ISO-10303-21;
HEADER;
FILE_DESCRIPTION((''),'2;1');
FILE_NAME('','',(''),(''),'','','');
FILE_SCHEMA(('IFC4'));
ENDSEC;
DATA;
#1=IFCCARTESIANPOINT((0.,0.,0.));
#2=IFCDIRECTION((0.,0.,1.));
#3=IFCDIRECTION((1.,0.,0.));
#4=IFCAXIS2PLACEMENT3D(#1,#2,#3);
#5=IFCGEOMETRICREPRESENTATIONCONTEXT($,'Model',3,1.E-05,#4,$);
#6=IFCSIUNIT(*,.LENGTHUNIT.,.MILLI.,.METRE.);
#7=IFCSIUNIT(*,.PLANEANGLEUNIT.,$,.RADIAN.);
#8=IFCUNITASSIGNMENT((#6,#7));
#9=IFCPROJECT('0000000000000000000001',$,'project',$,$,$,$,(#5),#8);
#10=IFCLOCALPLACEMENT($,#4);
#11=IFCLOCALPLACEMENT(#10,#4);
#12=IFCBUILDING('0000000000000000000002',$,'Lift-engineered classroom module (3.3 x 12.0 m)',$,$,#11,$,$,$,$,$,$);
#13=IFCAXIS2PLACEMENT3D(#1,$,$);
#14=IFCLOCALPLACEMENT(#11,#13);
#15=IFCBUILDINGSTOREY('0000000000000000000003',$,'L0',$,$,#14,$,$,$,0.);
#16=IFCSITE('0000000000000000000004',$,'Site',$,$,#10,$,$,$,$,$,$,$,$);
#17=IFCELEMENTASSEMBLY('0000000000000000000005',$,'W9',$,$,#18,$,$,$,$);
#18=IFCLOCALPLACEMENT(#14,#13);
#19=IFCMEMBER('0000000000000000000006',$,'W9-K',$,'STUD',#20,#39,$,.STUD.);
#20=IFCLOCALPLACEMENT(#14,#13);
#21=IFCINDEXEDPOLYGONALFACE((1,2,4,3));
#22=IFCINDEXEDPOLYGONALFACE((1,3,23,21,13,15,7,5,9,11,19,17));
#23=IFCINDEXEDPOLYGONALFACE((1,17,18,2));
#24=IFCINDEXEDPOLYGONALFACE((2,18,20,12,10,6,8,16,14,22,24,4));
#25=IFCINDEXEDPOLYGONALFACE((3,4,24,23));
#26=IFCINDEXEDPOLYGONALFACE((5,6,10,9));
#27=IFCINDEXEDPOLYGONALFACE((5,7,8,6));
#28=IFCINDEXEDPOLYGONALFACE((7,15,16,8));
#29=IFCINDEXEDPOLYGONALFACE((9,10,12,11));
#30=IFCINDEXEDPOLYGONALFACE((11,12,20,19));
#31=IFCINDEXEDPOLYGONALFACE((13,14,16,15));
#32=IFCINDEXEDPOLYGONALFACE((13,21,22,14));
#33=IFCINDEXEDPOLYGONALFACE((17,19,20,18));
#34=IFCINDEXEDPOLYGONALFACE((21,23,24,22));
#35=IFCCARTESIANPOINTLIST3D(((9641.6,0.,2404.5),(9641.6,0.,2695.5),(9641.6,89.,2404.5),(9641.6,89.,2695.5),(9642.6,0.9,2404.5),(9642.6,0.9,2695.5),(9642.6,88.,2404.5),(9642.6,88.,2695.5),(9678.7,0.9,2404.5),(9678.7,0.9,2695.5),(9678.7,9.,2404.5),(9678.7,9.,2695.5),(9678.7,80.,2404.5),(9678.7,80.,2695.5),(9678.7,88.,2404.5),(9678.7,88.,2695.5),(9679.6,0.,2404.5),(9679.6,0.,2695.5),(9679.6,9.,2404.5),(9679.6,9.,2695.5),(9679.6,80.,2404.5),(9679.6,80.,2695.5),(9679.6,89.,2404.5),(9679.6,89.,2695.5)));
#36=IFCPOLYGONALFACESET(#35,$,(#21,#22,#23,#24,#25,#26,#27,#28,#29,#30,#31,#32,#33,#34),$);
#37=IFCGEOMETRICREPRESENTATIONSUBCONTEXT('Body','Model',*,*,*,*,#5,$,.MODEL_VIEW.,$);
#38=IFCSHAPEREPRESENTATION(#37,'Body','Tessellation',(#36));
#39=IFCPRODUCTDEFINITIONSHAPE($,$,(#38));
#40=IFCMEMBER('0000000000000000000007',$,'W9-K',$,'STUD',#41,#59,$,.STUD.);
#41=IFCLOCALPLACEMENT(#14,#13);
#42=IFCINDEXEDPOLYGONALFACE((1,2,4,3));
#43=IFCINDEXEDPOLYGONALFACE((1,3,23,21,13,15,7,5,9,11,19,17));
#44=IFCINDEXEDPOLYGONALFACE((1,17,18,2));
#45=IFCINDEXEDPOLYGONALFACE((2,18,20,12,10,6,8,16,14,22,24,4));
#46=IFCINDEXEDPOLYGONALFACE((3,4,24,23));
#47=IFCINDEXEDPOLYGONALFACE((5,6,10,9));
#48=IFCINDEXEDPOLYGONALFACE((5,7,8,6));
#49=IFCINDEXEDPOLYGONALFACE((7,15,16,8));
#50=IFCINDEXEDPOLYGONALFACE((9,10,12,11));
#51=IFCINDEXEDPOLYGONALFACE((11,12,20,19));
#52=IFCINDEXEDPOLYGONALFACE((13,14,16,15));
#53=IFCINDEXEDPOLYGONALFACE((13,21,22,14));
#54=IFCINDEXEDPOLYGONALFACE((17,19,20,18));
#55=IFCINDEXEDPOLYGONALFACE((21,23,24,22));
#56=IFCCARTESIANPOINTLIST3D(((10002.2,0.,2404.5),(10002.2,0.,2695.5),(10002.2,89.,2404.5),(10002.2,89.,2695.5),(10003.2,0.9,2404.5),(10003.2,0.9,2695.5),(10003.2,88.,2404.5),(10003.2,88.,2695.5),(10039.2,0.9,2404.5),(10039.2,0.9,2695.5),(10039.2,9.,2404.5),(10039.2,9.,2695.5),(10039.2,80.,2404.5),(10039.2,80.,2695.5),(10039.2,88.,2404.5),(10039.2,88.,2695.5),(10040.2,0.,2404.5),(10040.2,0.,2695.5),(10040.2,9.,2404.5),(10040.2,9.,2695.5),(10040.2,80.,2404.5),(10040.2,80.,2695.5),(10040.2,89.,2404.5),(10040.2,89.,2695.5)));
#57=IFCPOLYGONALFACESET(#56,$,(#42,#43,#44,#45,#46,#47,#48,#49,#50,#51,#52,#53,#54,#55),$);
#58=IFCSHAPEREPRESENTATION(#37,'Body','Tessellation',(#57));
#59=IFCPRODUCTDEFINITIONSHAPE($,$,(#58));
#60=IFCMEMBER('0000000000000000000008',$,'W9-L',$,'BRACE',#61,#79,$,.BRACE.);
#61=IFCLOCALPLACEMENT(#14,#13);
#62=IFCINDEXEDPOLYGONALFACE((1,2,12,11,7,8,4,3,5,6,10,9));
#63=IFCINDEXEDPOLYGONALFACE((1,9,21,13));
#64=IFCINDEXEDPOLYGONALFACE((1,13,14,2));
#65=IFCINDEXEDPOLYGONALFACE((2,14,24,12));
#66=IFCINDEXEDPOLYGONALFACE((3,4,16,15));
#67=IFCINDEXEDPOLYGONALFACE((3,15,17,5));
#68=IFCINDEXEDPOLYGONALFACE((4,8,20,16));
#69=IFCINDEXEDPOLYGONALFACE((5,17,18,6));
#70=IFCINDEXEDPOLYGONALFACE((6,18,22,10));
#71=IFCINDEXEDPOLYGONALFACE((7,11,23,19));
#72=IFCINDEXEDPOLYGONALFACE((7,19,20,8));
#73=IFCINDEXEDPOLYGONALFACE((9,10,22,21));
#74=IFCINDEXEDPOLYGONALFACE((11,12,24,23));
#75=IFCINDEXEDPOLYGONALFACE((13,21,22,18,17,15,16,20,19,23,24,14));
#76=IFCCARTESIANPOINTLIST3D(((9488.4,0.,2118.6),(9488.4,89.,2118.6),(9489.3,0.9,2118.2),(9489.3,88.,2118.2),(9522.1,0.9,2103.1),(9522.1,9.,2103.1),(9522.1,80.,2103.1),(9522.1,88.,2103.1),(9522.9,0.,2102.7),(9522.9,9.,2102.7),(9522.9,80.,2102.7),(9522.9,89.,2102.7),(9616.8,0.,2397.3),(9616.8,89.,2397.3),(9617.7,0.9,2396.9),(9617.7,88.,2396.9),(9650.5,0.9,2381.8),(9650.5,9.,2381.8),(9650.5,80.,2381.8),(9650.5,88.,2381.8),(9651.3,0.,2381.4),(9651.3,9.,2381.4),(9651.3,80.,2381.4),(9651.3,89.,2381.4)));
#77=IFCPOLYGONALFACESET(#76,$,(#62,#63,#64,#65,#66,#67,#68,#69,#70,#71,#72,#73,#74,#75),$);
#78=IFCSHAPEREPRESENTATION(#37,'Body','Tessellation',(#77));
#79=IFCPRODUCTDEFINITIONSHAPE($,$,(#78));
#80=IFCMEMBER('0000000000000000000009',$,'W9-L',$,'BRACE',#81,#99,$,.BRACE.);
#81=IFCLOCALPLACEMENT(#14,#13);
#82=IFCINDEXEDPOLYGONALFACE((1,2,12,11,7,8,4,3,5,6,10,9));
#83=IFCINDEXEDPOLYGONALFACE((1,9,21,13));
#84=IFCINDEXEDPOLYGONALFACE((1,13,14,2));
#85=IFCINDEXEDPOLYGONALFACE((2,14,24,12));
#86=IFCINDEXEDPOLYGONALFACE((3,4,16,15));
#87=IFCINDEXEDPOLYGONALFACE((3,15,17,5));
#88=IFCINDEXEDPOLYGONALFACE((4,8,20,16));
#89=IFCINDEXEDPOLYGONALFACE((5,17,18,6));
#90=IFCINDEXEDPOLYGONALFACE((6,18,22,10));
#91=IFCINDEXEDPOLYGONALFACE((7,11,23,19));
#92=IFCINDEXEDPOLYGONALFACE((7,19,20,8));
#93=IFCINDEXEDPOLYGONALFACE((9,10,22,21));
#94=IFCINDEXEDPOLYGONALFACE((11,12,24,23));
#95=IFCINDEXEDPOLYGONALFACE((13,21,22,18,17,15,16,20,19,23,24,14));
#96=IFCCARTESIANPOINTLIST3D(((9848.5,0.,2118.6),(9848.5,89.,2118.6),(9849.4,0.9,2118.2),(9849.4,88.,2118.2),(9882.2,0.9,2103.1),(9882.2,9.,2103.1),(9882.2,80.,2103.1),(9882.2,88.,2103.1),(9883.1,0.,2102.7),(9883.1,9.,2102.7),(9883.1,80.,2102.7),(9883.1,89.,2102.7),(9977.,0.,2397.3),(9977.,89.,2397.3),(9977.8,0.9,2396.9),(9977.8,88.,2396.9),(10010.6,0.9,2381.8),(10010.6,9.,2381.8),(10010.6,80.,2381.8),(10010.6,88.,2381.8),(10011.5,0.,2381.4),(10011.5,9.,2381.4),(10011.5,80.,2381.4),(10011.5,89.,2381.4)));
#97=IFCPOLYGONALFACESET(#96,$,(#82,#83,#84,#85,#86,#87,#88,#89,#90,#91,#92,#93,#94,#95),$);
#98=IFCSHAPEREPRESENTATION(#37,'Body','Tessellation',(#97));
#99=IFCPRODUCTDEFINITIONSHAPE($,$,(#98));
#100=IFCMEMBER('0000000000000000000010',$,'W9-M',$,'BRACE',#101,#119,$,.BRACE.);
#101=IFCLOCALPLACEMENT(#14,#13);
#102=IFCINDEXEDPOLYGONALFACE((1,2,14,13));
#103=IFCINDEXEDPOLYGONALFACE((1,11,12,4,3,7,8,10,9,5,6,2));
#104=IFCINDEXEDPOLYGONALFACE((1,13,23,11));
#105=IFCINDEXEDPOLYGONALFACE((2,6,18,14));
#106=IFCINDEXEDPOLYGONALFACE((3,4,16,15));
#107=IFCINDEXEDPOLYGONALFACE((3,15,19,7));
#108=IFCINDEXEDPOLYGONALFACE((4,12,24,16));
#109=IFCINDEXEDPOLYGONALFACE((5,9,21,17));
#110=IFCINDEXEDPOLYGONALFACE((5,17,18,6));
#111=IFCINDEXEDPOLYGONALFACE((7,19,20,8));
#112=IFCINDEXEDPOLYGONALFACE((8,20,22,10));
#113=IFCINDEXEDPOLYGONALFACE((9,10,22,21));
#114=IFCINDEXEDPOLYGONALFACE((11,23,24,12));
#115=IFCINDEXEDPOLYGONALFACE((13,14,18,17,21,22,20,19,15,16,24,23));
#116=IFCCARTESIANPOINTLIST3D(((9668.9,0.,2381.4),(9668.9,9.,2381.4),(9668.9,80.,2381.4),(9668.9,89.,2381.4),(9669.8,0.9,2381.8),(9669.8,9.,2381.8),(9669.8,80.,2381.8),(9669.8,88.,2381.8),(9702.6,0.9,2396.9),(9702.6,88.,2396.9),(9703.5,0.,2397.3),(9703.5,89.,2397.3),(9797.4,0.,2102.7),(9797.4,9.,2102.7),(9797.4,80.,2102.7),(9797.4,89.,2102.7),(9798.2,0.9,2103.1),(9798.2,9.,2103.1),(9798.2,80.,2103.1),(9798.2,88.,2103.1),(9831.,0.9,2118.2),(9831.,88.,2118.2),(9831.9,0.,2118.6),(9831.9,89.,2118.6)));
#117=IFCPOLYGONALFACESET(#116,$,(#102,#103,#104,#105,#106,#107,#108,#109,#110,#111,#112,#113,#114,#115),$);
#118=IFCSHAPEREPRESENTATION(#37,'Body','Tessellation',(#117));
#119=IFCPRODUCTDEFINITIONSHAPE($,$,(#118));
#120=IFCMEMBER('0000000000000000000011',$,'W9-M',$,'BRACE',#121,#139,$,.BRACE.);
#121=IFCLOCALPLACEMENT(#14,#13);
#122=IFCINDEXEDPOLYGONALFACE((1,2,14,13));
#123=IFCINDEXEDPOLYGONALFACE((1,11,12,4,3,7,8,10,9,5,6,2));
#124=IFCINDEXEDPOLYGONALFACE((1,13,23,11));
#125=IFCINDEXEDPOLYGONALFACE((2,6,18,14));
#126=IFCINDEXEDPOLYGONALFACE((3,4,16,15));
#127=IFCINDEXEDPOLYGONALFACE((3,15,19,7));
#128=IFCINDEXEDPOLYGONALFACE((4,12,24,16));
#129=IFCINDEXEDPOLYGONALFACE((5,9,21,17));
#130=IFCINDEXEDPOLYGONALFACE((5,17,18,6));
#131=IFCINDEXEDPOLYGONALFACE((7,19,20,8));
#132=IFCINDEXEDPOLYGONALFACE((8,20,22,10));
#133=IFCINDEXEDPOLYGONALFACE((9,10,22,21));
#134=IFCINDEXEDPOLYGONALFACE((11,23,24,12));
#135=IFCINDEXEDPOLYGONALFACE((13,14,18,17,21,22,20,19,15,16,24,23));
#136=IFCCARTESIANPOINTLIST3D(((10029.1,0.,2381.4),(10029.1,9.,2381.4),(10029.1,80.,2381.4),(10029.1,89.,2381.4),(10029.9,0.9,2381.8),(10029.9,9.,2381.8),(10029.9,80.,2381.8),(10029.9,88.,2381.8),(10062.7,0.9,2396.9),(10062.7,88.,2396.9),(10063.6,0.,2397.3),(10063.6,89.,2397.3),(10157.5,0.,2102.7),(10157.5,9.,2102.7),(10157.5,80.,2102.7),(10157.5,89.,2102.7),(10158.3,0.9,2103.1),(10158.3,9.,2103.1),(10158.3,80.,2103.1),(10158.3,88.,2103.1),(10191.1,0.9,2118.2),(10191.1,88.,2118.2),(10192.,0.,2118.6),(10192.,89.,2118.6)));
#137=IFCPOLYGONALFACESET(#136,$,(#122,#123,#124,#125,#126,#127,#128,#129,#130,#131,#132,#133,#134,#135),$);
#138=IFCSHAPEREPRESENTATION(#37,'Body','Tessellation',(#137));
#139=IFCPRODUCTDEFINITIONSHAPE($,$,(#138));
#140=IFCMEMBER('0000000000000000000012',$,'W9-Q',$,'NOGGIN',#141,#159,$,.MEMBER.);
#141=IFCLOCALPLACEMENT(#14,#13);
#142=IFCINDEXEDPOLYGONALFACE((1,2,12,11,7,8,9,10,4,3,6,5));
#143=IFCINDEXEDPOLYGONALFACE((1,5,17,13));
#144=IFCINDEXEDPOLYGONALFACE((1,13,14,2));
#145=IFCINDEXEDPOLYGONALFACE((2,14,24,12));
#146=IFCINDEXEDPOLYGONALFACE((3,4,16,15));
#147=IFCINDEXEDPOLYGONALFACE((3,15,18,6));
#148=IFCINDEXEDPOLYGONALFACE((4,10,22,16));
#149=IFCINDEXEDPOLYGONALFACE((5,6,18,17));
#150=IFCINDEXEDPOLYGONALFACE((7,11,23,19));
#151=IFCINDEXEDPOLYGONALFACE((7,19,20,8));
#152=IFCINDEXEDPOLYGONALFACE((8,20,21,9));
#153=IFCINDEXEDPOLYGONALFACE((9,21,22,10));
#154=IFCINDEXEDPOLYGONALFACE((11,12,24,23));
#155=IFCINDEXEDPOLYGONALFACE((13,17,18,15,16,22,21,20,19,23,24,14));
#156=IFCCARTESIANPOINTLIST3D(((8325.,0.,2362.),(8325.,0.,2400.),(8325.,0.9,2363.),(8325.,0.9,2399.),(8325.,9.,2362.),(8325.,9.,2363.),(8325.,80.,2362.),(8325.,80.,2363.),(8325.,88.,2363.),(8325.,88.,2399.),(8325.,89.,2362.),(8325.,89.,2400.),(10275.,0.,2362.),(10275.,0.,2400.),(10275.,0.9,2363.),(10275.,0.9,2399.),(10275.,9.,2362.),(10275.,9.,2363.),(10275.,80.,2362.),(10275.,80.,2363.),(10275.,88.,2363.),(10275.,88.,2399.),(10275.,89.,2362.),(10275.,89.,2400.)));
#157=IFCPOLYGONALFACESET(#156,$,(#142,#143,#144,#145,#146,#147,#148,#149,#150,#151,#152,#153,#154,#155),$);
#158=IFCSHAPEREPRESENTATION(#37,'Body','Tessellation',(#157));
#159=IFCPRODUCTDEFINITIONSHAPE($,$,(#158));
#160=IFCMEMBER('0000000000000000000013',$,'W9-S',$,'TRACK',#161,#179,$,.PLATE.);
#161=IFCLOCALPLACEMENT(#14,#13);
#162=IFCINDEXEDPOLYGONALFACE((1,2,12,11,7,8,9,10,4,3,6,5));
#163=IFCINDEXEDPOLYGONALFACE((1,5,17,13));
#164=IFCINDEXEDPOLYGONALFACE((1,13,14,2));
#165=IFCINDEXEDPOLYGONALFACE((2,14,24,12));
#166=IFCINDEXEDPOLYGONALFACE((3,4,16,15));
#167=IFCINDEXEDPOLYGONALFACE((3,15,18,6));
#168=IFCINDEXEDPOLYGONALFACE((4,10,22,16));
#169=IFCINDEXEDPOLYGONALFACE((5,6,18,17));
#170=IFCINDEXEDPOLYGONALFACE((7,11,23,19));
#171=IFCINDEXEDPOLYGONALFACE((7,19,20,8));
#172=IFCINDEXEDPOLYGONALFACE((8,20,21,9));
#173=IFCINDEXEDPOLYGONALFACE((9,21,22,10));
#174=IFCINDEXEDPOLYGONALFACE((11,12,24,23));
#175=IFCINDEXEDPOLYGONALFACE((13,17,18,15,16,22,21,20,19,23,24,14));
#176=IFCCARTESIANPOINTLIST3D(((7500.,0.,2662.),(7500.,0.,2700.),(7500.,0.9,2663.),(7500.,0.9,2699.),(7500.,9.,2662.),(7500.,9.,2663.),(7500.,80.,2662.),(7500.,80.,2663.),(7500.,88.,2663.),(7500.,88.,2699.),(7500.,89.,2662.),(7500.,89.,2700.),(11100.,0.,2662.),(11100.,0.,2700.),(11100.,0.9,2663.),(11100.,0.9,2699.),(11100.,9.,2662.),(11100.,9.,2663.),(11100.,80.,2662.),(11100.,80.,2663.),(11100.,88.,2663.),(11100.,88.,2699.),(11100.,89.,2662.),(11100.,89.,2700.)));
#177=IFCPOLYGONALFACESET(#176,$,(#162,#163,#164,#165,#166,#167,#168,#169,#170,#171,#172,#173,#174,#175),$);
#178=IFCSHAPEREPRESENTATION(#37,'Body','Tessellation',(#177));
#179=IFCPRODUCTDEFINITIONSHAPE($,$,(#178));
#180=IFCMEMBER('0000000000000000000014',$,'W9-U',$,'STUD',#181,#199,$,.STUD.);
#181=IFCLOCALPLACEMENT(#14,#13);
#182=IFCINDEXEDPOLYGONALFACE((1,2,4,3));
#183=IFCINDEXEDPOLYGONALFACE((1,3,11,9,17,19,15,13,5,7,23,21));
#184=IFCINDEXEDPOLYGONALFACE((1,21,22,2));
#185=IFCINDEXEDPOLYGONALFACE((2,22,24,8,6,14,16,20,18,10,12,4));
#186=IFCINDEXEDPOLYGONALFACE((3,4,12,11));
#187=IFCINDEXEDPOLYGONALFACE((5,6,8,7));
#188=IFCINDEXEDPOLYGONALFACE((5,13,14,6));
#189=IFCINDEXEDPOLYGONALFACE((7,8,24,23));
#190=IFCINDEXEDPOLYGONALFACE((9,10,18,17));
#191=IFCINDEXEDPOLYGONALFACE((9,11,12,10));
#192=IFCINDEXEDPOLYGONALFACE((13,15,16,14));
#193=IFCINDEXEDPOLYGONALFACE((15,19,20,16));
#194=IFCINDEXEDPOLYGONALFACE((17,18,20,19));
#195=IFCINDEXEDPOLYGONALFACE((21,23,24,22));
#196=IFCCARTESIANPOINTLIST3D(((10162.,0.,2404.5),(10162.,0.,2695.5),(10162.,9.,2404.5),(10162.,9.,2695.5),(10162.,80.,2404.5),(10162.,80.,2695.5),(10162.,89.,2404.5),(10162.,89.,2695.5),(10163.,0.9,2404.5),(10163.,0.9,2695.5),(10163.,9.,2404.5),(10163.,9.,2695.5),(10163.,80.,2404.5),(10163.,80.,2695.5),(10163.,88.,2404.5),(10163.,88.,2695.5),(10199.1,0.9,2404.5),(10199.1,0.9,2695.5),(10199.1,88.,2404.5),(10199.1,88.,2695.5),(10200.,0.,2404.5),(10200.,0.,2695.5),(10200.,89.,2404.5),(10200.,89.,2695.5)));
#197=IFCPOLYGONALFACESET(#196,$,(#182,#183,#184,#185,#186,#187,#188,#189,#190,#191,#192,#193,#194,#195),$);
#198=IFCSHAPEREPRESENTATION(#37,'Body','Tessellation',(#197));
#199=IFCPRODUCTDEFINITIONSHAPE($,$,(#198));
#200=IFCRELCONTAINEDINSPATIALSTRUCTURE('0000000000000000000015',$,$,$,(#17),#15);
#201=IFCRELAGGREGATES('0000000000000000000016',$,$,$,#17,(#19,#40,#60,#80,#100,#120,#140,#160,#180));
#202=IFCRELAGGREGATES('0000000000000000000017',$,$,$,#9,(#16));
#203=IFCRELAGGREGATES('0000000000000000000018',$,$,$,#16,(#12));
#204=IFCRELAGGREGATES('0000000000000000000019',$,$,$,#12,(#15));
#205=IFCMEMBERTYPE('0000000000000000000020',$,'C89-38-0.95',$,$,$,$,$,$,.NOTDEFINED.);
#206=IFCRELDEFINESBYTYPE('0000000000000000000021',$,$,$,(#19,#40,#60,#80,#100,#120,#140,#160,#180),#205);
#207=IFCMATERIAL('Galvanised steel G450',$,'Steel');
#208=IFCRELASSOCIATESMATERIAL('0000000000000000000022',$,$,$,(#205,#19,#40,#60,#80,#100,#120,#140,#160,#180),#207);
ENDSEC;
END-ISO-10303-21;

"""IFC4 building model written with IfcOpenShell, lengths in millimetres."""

from ifc_helpers import new_model, si_unit, frame, origin, origin_with_axes, origin_2d, place, context, subcontext, project, spatial, c_section, extrude, material, material_profile, profile_set, profile_usage, type_object, element, aggregate, save


model = new_model("IFC4")

# Units and contexts
model_context = context("Model", 3, precision=1e-05, world=origin_with_axes())
body_context = subcontext(model_context, "Body", "Model", "MODEL_VIEW")
ifc_project = project(units=[si_unit("LENGTHUNIT", "METRE", prefix="MILLI"), si_unit("PLANEANGLEUNIT", "RADIAN")], contexts=[model_context])

# Site, building, storey
site_placement = place(None, origin_with_axes())
site = spatial("IfcSite", under=ifc_project, at=site_placement, Name="Site")
building_placement = place(site_placement, origin_with_axes())
building = spatial("IfcBuilding", under=site, at=building_placement, Name="Lift-engineered classroom module (3.3 x 12.0 m)")
storey_placement = place(building_placement, origin())
storey = spatial("IfcBuildingStorey", under=building, at=storey_placement, Name="L0", Elevation=0.0)

# Element assembly, members
assembly_1_placement = place(storey_placement, frame((7500.0, 44.5, 0.0)))
assembly_1 = element("IfcElementAssembly", 1, at=assembly_1_placement, inside=storey, Name="W9")
ifc_material = material(Name="Galvanised steel G450", Category="Steel")
ifc_material_profile = material_profile(ifc_material, c_section(Depth=89.0, Width=38.0, WallThickness=0.9, Girth=9.0, at=origin_2d()), Name="C89-38-0.95")
ifc_profile_set = profile_set([ifc_material_profile], Name="C89-38-0.95")
ifc_profile_usage = profile_usage(ifc_profile_set)
member_type = type_object("IfcMemberType", Name="C89-38-0.95", PredefinedType="NOTDEFINED", material=ifc_profile_set)
member_1_placement = place(assembly_1_placement, frame((2160.6, 0.0, 2695.5), z_axis=(0.0, 0.0, -1.0), x_axis=(1.0, 0.0, 0.0)))
member_1 = element("IfcMember", 2, at=member_1_placement, type_object=member_type, material=ifc_profile_usage, Name="W9-K", ObjectType="STUD", PredefinedType="STUD", context=body_context, shape_type="SweptSolid", body=[
    extrude(c_section(Depth=89.0, Width=38.0, WallThickness=0.9, Girth=9.0, at=origin_2d()), origin(), (0.0, 0.0, 1.0), 291.0),
])
member_2_placement = place(assembly_1_placement, frame((2521.2, 0.0, 2695.5), z_axis=(0.0, 0.0, -1.0), x_axis=(1.0, 0.0, 0.0)))
member_2 = element("IfcMember", 3, at=member_2_placement, type_object=member_type, material=ifc_profile_usage, Name="W9-K", ObjectType="STUD", PredefinedType="STUD", context=body_context, shape_type="SweptSolid", body=[
    extrude(c_section(Depth=89.0, Width=38.0, WallThickness=0.9, Girth=9.0, at=origin_2d()), origin(), (0.0, 0.0, 1.0), 291.0),
])
member_3_placement = place(assembly_1_placement, frame((2134.1, 0.0, 2389.3), z_axis=(-0.418465, 0.0, -0.908233), x_axis=(0.908233, 0.0, -0.418465)))
member_3 = element("IfcMember", 4, at=member_3_placement, type_object=member_type, material=ifc_profile_usage, Name="W9-L", ObjectType="BRACE", PredefinedType="BRACE", context=body_context, shape_type="SweptSolid", body=[
    extrude(c_section(Depth=89.0, Width=38.0, WallThickness=0.9, Girth=9.0, at=origin_2d()), origin(), (0.0, 0.0, 1.0), 306.9),
])
member_4_placement = place(assembly_1_placement, frame((2494.2, 0.0, 2389.3), z_axis=(-0.418465, 0.0, -0.908233), x_axis=(0.908233, 0.0, -0.418465)))
member_4 = element("IfcMember", 5, at=member_4_placement, type_object=member_type, material=ifc_profile_usage, Name="W9-L", ObjectType="BRACE", PredefinedType="BRACE", context=body_context, shape_type="SweptSolid", body=[
    extrude(c_section(Depth=89.0, Width=38.0, WallThickness=0.9, Girth=9.0, at=origin_2d()), origin(), (0.0, 0.0, 1.0), 306.9),
])
member_5_placement = place(assembly_1_placement, frame((2314.6, 0.0, 2110.6), z_axis=(-0.418465, 0.0, 0.908233), x_axis=(-0.908233, 0.0, -0.418465)))
member_5 = element("IfcMember", 6, at=member_5_placement, type_object=member_type, material=ifc_profile_usage, Name="W9-M", ObjectType="BRACE", PredefinedType="BRACE", context=body_context, shape_type="SweptSolid", body=[
    extrude(c_section(Depth=89.0, Width=38.0, WallThickness=0.9, Girth=9.0, at=origin_2d()), origin(), (0.0, 0.0, 1.0), 306.9),
])
member_6_placement = place(assembly_1_placement, frame((2674.7, 0.0, 2110.6), z_axis=(-0.418465, 0.0, 0.908233), x_axis=(-0.908233, 0.0, -0.418465)))
member_6 = element("IfcMember", 7, at=member_6_placement, type_object=member_type, material=ifc_profile_usage, Name="W9-M", ObjectType="BRACE", PredefinedType="BRACE", context=body_context, shape_type="SweptSolid", body=[
    extrude(c_section(Depth=89.0, Width=38.0, WallThickness=0.9, Girth=9.0, at=origin_2d()), origin(), (0.0, 0.0, 1.0), 306.9),
])
member_7_placement = place(assembly_1_placement, frame((2775.0, 0.0, 2381.0), z_axis=(-1.0, 0.0, 0.0), x_axis=(0.0, 0.0, -1.0)))
member_7 = element("IfcMember", 8, at=member_7_placement, type_object=member_type, material=ifc_profile_usage, Name="W9-Q", ObjectType="NOGGIN", PredefinedType="MEMBER", context=body_context, shape_type="SweptSolid", body=[
    extrude(c_section(Depth=89.0, Width=38.0, WallThickness=0.9, Girth=9.0, at=origin_2d()), origin(), (0.0, 0.0, 1.0), 1950.1),
])
member_8_placement = place(assembly_1_placement, frame((3600.0, 0.0, 2681.0), z_axis=(-1.0, 0.0, 0.0), x_axis=(0.0, 0.0, -1.0)))
member_8 = element("IfcMember", 9, at=member_8_placement, type_object=member_type, material=ifc_profile_usage, Name="W9-S", ObjectType="TRACK", PredefinedType="PLATE", context=body_context, shape_type="SweptSolid", body=[
    extrude(c_section(Depth=89.0, Width=38.0, WallThickness=0.9, Girth=9.0, at=origin_2d()), origin(), (0.0, 0.0, 1.0), 3600.0),
])
member_9_placement = place(assembly_1_placement, frame((2681.0, 0.0, 2404.5), z_axis=(0.0, 0.0, 1.0), x_axis=(-1.0, 0.0, 0.0)))
member_9 = element("IfcMember", 10, at=member_9_placement, type_object=member_type, material=ifc_profile_usage, Name="W9-U", ObjectType="STUD", PredefinedType="STUD", context=body_context, shape_type="SweptSolid", body=[
    extrude(c_section(Depth=89.0, Width=38.0, WallThickness=0.9, Girth=9.0, at=origin_2d()), origin(), (0.0, 0.0, 1.0), 291.0),
])
aggregate(assembly_1, [member_1, member_2, member_3, member_4, member_5, member_6, member_7, member_8, member_9])

save(model, "model.ifc")
